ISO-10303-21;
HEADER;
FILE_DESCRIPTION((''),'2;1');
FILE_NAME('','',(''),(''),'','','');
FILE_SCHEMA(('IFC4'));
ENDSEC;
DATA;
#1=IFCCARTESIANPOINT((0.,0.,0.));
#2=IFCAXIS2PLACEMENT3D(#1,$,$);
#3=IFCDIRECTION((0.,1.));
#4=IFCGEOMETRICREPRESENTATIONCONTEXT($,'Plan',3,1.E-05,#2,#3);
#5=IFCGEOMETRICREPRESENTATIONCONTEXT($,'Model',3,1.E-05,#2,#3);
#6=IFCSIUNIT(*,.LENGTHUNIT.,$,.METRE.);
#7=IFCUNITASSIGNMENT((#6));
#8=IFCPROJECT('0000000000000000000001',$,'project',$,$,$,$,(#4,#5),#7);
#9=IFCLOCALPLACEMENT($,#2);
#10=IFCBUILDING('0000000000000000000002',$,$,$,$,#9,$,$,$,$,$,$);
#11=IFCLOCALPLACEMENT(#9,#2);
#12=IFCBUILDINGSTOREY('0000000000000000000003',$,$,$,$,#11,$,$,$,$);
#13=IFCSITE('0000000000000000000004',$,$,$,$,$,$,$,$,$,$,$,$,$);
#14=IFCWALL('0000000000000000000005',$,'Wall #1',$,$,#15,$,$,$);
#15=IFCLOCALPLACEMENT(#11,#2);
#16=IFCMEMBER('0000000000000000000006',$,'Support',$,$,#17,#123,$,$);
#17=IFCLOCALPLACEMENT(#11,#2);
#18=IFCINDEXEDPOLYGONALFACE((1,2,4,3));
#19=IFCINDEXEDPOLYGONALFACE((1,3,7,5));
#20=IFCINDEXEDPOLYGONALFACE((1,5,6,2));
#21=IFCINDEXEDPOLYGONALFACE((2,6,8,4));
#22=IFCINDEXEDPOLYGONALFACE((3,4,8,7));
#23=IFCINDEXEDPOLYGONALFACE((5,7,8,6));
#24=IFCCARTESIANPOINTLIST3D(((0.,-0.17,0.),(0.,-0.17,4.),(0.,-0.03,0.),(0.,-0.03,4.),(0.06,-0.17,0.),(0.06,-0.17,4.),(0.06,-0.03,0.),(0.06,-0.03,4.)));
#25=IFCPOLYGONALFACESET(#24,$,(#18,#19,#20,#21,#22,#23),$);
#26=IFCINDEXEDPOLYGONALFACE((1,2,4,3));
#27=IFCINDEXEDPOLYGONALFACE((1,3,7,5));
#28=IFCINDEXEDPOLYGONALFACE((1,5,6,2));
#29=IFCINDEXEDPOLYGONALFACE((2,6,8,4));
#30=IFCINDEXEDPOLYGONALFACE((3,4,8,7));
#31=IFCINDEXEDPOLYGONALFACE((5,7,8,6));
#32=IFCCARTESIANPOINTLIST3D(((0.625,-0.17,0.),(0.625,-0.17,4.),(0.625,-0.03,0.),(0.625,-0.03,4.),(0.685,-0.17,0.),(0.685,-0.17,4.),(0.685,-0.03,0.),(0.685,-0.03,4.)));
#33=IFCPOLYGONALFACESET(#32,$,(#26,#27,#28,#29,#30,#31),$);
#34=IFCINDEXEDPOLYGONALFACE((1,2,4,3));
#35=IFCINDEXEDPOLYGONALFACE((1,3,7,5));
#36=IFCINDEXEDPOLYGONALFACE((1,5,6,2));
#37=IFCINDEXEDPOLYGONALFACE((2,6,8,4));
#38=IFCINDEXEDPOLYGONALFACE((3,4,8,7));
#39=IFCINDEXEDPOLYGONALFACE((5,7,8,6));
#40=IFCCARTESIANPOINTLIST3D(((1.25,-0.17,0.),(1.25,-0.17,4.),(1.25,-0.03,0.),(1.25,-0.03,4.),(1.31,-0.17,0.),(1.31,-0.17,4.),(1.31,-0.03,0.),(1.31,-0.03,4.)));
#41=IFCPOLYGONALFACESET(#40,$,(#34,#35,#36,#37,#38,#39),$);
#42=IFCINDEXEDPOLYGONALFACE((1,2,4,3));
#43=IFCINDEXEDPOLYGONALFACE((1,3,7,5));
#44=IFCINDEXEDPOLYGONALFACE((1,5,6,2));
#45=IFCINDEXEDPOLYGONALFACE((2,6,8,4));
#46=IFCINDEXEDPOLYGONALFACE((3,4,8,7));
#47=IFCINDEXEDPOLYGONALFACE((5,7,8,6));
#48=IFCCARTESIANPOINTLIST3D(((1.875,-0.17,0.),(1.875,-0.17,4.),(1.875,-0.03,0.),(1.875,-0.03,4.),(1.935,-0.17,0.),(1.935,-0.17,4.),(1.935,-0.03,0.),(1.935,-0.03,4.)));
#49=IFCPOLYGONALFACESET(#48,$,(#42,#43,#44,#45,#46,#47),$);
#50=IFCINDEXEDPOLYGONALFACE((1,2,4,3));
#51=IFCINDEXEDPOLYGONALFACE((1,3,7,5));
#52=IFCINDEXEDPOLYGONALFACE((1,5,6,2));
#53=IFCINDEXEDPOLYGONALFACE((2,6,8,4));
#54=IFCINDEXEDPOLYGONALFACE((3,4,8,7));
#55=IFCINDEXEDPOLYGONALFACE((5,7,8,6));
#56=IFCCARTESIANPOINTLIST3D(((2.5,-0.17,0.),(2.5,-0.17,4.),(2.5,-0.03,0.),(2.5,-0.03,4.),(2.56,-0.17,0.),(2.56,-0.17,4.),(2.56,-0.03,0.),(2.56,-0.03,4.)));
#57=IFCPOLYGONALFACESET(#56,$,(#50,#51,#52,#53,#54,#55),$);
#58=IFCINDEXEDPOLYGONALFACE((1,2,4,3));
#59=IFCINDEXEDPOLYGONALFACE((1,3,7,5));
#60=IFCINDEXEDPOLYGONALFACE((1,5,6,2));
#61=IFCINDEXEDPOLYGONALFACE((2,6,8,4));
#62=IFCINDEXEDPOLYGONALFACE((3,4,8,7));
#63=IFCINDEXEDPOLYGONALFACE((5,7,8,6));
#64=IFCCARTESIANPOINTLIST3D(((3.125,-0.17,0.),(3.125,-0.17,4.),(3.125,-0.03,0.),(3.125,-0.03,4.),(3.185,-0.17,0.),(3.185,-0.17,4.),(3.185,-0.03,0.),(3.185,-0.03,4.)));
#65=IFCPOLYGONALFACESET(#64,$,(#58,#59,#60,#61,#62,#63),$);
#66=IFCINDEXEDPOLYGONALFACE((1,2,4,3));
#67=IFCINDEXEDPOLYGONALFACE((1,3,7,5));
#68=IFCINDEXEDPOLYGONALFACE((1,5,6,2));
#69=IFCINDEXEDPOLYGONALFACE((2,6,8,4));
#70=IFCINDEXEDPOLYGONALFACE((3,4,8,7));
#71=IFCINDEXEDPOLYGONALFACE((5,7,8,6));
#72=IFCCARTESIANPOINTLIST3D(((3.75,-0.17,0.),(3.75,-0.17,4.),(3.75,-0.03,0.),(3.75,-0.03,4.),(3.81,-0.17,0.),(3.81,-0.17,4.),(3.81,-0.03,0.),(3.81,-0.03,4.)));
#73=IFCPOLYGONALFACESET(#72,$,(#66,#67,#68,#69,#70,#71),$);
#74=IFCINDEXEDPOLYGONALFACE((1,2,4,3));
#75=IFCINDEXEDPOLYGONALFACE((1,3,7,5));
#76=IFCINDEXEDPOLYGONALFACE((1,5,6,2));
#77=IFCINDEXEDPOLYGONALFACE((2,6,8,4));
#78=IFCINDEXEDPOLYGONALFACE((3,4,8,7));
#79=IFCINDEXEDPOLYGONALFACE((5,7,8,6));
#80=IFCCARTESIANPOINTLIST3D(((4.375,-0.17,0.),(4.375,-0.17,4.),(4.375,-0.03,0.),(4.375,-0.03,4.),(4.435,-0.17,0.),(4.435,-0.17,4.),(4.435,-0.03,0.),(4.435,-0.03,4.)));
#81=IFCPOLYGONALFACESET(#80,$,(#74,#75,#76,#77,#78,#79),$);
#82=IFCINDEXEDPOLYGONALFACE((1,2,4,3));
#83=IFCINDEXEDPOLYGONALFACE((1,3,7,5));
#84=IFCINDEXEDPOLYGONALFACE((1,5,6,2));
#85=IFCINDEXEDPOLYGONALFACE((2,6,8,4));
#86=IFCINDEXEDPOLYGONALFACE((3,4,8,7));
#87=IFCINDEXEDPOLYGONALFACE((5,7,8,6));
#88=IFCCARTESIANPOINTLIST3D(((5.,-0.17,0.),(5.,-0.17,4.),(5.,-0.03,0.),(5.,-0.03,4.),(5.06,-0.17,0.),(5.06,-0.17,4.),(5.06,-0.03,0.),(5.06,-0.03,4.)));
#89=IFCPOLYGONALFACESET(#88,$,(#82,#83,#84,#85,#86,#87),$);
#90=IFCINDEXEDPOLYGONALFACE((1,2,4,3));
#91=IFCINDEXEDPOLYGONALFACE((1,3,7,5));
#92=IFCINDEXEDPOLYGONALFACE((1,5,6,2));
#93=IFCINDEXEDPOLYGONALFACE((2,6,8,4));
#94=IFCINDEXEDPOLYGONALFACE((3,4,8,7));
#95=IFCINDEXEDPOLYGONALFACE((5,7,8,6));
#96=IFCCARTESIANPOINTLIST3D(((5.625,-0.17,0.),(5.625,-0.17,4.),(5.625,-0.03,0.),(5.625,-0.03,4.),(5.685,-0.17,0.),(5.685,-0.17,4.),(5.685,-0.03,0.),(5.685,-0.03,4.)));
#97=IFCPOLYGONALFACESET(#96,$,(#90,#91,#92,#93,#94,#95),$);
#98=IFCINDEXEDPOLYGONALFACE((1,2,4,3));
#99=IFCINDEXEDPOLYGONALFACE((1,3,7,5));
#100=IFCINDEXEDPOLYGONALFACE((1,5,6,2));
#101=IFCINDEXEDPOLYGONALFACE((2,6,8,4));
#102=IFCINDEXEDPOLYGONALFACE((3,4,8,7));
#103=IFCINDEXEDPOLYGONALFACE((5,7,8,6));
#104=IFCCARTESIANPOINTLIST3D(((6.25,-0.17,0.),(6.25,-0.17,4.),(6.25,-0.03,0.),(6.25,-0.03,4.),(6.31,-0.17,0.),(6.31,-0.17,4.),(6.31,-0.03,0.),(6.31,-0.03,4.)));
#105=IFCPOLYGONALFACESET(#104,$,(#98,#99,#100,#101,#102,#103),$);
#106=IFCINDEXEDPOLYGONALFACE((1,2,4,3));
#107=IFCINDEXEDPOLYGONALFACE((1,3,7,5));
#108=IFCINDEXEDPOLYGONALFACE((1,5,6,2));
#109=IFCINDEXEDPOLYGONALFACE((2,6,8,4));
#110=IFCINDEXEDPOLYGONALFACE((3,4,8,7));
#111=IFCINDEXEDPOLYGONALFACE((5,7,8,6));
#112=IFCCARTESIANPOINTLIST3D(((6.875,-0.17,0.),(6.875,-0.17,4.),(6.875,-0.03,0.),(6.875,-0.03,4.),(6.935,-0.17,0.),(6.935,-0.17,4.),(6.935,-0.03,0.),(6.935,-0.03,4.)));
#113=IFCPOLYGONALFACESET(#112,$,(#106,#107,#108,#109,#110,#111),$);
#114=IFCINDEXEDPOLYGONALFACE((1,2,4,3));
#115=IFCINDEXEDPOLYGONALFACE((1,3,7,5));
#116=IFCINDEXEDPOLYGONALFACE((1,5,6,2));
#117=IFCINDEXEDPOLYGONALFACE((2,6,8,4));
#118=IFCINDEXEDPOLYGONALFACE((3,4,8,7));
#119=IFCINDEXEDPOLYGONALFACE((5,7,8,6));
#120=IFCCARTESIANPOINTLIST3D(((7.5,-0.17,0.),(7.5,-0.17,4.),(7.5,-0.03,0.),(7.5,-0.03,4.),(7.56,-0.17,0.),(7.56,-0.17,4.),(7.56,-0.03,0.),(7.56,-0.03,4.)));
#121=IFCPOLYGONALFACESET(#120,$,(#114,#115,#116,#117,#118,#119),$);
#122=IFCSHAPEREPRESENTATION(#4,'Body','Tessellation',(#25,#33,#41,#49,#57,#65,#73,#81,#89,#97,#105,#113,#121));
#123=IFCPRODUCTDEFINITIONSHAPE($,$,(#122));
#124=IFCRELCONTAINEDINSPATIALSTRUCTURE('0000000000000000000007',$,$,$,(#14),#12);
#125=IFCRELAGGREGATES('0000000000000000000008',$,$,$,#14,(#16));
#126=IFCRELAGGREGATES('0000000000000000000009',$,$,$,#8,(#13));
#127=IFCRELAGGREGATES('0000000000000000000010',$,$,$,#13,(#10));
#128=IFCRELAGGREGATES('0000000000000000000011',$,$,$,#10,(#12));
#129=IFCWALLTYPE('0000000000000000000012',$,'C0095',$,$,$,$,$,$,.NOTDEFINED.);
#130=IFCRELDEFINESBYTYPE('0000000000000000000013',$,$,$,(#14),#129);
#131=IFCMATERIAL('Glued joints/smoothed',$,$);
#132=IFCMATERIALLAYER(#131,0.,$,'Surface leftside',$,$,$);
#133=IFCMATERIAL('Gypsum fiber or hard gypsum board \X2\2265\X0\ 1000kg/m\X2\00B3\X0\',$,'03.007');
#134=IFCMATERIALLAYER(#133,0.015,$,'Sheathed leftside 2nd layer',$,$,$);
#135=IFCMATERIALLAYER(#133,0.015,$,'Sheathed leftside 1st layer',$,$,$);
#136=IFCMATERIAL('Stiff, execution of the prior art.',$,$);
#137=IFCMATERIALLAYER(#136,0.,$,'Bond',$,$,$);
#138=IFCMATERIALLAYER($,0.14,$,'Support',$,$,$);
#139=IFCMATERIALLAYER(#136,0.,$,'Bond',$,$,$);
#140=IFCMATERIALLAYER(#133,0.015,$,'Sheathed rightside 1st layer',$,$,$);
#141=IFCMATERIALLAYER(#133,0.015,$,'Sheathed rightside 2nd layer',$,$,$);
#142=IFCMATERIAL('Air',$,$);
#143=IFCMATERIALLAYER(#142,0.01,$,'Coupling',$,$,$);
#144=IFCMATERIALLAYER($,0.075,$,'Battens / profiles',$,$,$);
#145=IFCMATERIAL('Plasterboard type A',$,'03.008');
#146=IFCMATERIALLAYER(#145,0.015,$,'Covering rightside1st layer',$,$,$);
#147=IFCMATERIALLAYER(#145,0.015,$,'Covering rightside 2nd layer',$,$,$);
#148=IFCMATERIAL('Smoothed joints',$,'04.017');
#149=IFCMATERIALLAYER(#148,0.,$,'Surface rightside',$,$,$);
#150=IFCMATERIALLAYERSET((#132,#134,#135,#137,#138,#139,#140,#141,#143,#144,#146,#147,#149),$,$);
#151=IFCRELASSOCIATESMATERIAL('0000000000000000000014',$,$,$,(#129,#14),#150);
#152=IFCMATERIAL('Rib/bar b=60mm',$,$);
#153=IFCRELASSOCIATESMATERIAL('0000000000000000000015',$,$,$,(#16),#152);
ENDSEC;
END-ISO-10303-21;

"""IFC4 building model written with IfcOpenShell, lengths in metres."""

from ifc_helpers import new_model, si_unit, direction, frame, frame_2d, origin, place, context, project, spatial, rectangle, extrude, material, layer, layer_set, type_object, element, aggregate, save


model = new_model("IFC4")

# Units and contexts
plan_context = context("Plan", 3, precision=1e-05, world=origin(), true_north=direction((0.0, 1.0)))
model_context = context("Model", 3, precision=1e-05, world=origin(), true_north=direction((0.0, 1.0)))
ifc_project = project(units=[si_unit("LENGTHUNIT", "METRE")], contexts=[plan_context, model_context])

# Site, building, storey
site = spatial("IfcSite", under=ifc_project)
building_placement = place(None, origin())
building = spatial("IfcBuilding", under=site, at=building_placement)
storey_placement = place(building_placement, origin())
storey = spatial("IfcBuildingStorey", under=building, at=storey_placement)

# Wall, member
ifc_material_1 = material(Name="Glued joints/smoothed")
ifc_layer_1 = layer(ifc_material_1, 0.0, Name="Surface leftside")
ifc_material_2 = material(Name="Gypsum fiber or hard gypsum board ≥ 1000kg/m³", Category="03.007")
ifc_layer_2 = layer(ifc_material_2, 0.015, Name="Sheathed leftside 2nd layer")
ifc_layer_3 = layer(ifc_material_2, 0.015, Name="Sheathed leftside 1st layer")
ifc_material_3 = material(Name="Stiff, execution of the prior art.")
ifc_layer_4 = layer(ifc_material_3, 0.0, Name="Bond")
ifc_layer_5 = layer(None, 0.14, Name="Support")
ifc_layer_6 = layer(ifc_material_3, 0.0, Name="Bond")
ifc_layer_7 = layer(ifc_material_2, 0.015, Name="Sheathed rightside 1st layer")
ifc_layer_8 = layer(ifc_material_2, 0.015, Name="Sheathed rightside 2nd layer")
ifc_material_4 = material(Name="Air")
ifc_layer_9 = layer(ifc_material_4, 0.01, Name="Coupling")
ifc_layer_10 = layer(None, 0.075, Name="Battens / profiles")
ifc_material_5 = material(Name="Plasterboard type A", Category="03.008")
ifc_layer_11 = layer(ifc_material_5, 0.015, Name="Covering rightside1st layer")
ifc_layer_12 = layer(ifc_material_5, 0.015, Name="Covering rightside 2nd layer")
ifc_material_6 = material(Name="Smoothed joints", Category="04.017")
ifc_layer_13 = layer(ifc_material_6, 0.0, Name="Surface rightside")
ifc_layer_set = layer_set([ifc_layer_1, ifc_layer_2, ifc_layer_3, ifc_layer_4, ifc_layer_5, ifc_layer_6, ifc_layer_7, ifc_layer_8, ifc_layer_9, ifc_layer_10, ifc_layer_11, ifc_layer_12, ifc_layer_13])
wall_type = type_object("IfcWallType", Name="C0095", PredefinedType="NOTDEFINED", material=ifc_layer_set)
wall_placement = place(None, frame((0.0, 0.0, 0.0), z_axis=(0.0, -1.0, 0.0), x_axis=(1.0, 0.0, 0.0)))
wall = element("IfcWall", 1, at=wall_placement, inside=storey, type_object=wall_type, material=ifc_layer_set, Name="Wall #1")
ifc_material_7 = material(Name="Rib/bar b=60mm")
member_1_placement = place(wall_placement, origin())
member_1 = element("IfcMember", 2, at=member_1_placement, material=ifc_material_7, Name="Support", context=plan_context, shape_type="SweptSolid", body=[
    extrude(rectangle(XDim=0.06, YDim=0.14, at=frame_2d((0.03, 0.07), x_axis=(1.0, 0.0))), frame((0.0, 4.0, 0.03), z_axis=(0.0, -1.0, 0.0), x_axis=(1.0, 0.0, 0.0)), (0.0, 0.0, 1.0), 4.0),
    extrude(rectangle(XDim=0.06, YDim=0.14, at=frame_2d((0.03, 0.07), x_axis=(1.0, 0.0))), frame((0.625, 4.0, 0.03), z_axis=(0.0, -1.0, 0.0), x_axis=(1.0, 0.0, 0.0)), (0.0, 0.0, 1.0), 4.0),
    extrude(rectangle(XDim=0.06, YDim=0.14, at=frame_2d((0.03, 0.07), x_axis=(1.0, 0.0))), frame((1.25, 4.0, 0.03), z_axis=(0.0, -1.0, 0.0), x_axis=(1.0, 0.0, 0.0)), (0.0, 0.0, 1.0), 4.0),
    extrude(rectangle(XDim=0.06, YDim=0.14, at=frame_2d((0.03, 0.07), x_axis=(1.0, 0.0))), frame((1.875, 4.0, 0.03), z_axis=(0.0, -1.0, 0.0), x_axis=(1.0, 0.0, 0.0)), (0.0, 0.0, 1.0), 4.0),
    extrude(rectangle(XDim=0.06, YDim=0.14, at=frame_2d((0.03, 0.07), x_axis=(1.0, 0.0))), frame((2.5, 4.0, 0.03), z_axis=(0.0, -1.0, 0.0), x_axis=(1.0, 0.0, 0.0)), (0.0, 0.0, 1.0), 4.0),
    extrude(rectangle(XDim=0.06, YDim=0.14, at=frame_2d((0.03, 0.07), x_axis=(1.0, 0.0))), frame((3.125, 4.0, 0.03), z_axis=(0.0, -1.0, 0.0), x_axis=(1.0, 0.0, 0.0)), (0.0, 0.0, 1.0), 4.0),
    extrude(rectangle(XDim=0.06, YDim=0.14, at=frame_2d((0.03, 0.07), x_axis=(1.0, 0.0))), frame((3.75, 4.0, 0.03), z_axis=(0.0, -1.0, 0.0), x_axis=(1.0, 0.0, 0.0)), (0.0, 0.0, 1.0), 4.0),
    extrude(rectangle(XDim=0.06, YDim=0.14, at=frame_2d((0.03, 0.07), x_axis=(1.0, 0.0))), frame((4.375, 4.0, 0.03), z_axis=(0.0, -1.0, 0.0), x_axis=(1.0, 0.0, 0.0)), (0.0, 0.0, 1.0), 4.0),
    extrude(rectangle(XDim=0.06, YDim=0.14, at=frame_2d((0.03, 0.07), x_axis=(1.0, 0.0))), frame((5.0, 4.0, 0.03), z_axis=(0.0, -1.0, 0.0), x_axis=(1.0, 0.0, 0.0)), (0.0, 0.0, 1.0), 4.0),
    extrude(rectangle(XDim=0.06, YDim=0.14, at=frame_2d((0.03, 0.07), x_axis=(1.0, 0.0))), frame((5.625, 4.0, 0.03), z_axis=(0.0, -1.0, 0.0), x_axis=(1.0, 0.0, 0.0)), (0.0, 0.0, 1.0), 4.0),
    extrude(rectangle(XDim=0.06, YDim=0.14, at=frame_2d((0.03, 0.07), x_axis=(1.0, 0.0))), frame((6.25, 4.0, 0.03), z_axis=(0.0, -1.0, 0.0), x_axis=(1.0, 0.0, 0.0)), (0.0, 0.0, 1.0), 4.0),
    extrude(rectangle(XDim=0.06, YDim=0.14, at=frame_2d((0.03, 0.07), x_axis=(1.0, 0.0))), frame((6.875, 4.0, 0.03), z_axis=(0.0, -1.0, 0.0), x_axis=(1.0, 0.0, 0.0)), (0.0, 0.0, 1.0), 4.0),
    extrude(rectangle(XDim=0.06, YDim=0.14, at=frame_2d((0.03, 0.07), x_axis=(1.0, 0.0))), frame((7.5, 4.0, 0.03), z_axis=(0.0, -1.0, 0.0), x_axis=(1.0, 0.0, 0.0)), (0.0, 0.0, 1.0), 4.0),
])
aggregate(wall, [member_1])

save(model, "model.ifc")
